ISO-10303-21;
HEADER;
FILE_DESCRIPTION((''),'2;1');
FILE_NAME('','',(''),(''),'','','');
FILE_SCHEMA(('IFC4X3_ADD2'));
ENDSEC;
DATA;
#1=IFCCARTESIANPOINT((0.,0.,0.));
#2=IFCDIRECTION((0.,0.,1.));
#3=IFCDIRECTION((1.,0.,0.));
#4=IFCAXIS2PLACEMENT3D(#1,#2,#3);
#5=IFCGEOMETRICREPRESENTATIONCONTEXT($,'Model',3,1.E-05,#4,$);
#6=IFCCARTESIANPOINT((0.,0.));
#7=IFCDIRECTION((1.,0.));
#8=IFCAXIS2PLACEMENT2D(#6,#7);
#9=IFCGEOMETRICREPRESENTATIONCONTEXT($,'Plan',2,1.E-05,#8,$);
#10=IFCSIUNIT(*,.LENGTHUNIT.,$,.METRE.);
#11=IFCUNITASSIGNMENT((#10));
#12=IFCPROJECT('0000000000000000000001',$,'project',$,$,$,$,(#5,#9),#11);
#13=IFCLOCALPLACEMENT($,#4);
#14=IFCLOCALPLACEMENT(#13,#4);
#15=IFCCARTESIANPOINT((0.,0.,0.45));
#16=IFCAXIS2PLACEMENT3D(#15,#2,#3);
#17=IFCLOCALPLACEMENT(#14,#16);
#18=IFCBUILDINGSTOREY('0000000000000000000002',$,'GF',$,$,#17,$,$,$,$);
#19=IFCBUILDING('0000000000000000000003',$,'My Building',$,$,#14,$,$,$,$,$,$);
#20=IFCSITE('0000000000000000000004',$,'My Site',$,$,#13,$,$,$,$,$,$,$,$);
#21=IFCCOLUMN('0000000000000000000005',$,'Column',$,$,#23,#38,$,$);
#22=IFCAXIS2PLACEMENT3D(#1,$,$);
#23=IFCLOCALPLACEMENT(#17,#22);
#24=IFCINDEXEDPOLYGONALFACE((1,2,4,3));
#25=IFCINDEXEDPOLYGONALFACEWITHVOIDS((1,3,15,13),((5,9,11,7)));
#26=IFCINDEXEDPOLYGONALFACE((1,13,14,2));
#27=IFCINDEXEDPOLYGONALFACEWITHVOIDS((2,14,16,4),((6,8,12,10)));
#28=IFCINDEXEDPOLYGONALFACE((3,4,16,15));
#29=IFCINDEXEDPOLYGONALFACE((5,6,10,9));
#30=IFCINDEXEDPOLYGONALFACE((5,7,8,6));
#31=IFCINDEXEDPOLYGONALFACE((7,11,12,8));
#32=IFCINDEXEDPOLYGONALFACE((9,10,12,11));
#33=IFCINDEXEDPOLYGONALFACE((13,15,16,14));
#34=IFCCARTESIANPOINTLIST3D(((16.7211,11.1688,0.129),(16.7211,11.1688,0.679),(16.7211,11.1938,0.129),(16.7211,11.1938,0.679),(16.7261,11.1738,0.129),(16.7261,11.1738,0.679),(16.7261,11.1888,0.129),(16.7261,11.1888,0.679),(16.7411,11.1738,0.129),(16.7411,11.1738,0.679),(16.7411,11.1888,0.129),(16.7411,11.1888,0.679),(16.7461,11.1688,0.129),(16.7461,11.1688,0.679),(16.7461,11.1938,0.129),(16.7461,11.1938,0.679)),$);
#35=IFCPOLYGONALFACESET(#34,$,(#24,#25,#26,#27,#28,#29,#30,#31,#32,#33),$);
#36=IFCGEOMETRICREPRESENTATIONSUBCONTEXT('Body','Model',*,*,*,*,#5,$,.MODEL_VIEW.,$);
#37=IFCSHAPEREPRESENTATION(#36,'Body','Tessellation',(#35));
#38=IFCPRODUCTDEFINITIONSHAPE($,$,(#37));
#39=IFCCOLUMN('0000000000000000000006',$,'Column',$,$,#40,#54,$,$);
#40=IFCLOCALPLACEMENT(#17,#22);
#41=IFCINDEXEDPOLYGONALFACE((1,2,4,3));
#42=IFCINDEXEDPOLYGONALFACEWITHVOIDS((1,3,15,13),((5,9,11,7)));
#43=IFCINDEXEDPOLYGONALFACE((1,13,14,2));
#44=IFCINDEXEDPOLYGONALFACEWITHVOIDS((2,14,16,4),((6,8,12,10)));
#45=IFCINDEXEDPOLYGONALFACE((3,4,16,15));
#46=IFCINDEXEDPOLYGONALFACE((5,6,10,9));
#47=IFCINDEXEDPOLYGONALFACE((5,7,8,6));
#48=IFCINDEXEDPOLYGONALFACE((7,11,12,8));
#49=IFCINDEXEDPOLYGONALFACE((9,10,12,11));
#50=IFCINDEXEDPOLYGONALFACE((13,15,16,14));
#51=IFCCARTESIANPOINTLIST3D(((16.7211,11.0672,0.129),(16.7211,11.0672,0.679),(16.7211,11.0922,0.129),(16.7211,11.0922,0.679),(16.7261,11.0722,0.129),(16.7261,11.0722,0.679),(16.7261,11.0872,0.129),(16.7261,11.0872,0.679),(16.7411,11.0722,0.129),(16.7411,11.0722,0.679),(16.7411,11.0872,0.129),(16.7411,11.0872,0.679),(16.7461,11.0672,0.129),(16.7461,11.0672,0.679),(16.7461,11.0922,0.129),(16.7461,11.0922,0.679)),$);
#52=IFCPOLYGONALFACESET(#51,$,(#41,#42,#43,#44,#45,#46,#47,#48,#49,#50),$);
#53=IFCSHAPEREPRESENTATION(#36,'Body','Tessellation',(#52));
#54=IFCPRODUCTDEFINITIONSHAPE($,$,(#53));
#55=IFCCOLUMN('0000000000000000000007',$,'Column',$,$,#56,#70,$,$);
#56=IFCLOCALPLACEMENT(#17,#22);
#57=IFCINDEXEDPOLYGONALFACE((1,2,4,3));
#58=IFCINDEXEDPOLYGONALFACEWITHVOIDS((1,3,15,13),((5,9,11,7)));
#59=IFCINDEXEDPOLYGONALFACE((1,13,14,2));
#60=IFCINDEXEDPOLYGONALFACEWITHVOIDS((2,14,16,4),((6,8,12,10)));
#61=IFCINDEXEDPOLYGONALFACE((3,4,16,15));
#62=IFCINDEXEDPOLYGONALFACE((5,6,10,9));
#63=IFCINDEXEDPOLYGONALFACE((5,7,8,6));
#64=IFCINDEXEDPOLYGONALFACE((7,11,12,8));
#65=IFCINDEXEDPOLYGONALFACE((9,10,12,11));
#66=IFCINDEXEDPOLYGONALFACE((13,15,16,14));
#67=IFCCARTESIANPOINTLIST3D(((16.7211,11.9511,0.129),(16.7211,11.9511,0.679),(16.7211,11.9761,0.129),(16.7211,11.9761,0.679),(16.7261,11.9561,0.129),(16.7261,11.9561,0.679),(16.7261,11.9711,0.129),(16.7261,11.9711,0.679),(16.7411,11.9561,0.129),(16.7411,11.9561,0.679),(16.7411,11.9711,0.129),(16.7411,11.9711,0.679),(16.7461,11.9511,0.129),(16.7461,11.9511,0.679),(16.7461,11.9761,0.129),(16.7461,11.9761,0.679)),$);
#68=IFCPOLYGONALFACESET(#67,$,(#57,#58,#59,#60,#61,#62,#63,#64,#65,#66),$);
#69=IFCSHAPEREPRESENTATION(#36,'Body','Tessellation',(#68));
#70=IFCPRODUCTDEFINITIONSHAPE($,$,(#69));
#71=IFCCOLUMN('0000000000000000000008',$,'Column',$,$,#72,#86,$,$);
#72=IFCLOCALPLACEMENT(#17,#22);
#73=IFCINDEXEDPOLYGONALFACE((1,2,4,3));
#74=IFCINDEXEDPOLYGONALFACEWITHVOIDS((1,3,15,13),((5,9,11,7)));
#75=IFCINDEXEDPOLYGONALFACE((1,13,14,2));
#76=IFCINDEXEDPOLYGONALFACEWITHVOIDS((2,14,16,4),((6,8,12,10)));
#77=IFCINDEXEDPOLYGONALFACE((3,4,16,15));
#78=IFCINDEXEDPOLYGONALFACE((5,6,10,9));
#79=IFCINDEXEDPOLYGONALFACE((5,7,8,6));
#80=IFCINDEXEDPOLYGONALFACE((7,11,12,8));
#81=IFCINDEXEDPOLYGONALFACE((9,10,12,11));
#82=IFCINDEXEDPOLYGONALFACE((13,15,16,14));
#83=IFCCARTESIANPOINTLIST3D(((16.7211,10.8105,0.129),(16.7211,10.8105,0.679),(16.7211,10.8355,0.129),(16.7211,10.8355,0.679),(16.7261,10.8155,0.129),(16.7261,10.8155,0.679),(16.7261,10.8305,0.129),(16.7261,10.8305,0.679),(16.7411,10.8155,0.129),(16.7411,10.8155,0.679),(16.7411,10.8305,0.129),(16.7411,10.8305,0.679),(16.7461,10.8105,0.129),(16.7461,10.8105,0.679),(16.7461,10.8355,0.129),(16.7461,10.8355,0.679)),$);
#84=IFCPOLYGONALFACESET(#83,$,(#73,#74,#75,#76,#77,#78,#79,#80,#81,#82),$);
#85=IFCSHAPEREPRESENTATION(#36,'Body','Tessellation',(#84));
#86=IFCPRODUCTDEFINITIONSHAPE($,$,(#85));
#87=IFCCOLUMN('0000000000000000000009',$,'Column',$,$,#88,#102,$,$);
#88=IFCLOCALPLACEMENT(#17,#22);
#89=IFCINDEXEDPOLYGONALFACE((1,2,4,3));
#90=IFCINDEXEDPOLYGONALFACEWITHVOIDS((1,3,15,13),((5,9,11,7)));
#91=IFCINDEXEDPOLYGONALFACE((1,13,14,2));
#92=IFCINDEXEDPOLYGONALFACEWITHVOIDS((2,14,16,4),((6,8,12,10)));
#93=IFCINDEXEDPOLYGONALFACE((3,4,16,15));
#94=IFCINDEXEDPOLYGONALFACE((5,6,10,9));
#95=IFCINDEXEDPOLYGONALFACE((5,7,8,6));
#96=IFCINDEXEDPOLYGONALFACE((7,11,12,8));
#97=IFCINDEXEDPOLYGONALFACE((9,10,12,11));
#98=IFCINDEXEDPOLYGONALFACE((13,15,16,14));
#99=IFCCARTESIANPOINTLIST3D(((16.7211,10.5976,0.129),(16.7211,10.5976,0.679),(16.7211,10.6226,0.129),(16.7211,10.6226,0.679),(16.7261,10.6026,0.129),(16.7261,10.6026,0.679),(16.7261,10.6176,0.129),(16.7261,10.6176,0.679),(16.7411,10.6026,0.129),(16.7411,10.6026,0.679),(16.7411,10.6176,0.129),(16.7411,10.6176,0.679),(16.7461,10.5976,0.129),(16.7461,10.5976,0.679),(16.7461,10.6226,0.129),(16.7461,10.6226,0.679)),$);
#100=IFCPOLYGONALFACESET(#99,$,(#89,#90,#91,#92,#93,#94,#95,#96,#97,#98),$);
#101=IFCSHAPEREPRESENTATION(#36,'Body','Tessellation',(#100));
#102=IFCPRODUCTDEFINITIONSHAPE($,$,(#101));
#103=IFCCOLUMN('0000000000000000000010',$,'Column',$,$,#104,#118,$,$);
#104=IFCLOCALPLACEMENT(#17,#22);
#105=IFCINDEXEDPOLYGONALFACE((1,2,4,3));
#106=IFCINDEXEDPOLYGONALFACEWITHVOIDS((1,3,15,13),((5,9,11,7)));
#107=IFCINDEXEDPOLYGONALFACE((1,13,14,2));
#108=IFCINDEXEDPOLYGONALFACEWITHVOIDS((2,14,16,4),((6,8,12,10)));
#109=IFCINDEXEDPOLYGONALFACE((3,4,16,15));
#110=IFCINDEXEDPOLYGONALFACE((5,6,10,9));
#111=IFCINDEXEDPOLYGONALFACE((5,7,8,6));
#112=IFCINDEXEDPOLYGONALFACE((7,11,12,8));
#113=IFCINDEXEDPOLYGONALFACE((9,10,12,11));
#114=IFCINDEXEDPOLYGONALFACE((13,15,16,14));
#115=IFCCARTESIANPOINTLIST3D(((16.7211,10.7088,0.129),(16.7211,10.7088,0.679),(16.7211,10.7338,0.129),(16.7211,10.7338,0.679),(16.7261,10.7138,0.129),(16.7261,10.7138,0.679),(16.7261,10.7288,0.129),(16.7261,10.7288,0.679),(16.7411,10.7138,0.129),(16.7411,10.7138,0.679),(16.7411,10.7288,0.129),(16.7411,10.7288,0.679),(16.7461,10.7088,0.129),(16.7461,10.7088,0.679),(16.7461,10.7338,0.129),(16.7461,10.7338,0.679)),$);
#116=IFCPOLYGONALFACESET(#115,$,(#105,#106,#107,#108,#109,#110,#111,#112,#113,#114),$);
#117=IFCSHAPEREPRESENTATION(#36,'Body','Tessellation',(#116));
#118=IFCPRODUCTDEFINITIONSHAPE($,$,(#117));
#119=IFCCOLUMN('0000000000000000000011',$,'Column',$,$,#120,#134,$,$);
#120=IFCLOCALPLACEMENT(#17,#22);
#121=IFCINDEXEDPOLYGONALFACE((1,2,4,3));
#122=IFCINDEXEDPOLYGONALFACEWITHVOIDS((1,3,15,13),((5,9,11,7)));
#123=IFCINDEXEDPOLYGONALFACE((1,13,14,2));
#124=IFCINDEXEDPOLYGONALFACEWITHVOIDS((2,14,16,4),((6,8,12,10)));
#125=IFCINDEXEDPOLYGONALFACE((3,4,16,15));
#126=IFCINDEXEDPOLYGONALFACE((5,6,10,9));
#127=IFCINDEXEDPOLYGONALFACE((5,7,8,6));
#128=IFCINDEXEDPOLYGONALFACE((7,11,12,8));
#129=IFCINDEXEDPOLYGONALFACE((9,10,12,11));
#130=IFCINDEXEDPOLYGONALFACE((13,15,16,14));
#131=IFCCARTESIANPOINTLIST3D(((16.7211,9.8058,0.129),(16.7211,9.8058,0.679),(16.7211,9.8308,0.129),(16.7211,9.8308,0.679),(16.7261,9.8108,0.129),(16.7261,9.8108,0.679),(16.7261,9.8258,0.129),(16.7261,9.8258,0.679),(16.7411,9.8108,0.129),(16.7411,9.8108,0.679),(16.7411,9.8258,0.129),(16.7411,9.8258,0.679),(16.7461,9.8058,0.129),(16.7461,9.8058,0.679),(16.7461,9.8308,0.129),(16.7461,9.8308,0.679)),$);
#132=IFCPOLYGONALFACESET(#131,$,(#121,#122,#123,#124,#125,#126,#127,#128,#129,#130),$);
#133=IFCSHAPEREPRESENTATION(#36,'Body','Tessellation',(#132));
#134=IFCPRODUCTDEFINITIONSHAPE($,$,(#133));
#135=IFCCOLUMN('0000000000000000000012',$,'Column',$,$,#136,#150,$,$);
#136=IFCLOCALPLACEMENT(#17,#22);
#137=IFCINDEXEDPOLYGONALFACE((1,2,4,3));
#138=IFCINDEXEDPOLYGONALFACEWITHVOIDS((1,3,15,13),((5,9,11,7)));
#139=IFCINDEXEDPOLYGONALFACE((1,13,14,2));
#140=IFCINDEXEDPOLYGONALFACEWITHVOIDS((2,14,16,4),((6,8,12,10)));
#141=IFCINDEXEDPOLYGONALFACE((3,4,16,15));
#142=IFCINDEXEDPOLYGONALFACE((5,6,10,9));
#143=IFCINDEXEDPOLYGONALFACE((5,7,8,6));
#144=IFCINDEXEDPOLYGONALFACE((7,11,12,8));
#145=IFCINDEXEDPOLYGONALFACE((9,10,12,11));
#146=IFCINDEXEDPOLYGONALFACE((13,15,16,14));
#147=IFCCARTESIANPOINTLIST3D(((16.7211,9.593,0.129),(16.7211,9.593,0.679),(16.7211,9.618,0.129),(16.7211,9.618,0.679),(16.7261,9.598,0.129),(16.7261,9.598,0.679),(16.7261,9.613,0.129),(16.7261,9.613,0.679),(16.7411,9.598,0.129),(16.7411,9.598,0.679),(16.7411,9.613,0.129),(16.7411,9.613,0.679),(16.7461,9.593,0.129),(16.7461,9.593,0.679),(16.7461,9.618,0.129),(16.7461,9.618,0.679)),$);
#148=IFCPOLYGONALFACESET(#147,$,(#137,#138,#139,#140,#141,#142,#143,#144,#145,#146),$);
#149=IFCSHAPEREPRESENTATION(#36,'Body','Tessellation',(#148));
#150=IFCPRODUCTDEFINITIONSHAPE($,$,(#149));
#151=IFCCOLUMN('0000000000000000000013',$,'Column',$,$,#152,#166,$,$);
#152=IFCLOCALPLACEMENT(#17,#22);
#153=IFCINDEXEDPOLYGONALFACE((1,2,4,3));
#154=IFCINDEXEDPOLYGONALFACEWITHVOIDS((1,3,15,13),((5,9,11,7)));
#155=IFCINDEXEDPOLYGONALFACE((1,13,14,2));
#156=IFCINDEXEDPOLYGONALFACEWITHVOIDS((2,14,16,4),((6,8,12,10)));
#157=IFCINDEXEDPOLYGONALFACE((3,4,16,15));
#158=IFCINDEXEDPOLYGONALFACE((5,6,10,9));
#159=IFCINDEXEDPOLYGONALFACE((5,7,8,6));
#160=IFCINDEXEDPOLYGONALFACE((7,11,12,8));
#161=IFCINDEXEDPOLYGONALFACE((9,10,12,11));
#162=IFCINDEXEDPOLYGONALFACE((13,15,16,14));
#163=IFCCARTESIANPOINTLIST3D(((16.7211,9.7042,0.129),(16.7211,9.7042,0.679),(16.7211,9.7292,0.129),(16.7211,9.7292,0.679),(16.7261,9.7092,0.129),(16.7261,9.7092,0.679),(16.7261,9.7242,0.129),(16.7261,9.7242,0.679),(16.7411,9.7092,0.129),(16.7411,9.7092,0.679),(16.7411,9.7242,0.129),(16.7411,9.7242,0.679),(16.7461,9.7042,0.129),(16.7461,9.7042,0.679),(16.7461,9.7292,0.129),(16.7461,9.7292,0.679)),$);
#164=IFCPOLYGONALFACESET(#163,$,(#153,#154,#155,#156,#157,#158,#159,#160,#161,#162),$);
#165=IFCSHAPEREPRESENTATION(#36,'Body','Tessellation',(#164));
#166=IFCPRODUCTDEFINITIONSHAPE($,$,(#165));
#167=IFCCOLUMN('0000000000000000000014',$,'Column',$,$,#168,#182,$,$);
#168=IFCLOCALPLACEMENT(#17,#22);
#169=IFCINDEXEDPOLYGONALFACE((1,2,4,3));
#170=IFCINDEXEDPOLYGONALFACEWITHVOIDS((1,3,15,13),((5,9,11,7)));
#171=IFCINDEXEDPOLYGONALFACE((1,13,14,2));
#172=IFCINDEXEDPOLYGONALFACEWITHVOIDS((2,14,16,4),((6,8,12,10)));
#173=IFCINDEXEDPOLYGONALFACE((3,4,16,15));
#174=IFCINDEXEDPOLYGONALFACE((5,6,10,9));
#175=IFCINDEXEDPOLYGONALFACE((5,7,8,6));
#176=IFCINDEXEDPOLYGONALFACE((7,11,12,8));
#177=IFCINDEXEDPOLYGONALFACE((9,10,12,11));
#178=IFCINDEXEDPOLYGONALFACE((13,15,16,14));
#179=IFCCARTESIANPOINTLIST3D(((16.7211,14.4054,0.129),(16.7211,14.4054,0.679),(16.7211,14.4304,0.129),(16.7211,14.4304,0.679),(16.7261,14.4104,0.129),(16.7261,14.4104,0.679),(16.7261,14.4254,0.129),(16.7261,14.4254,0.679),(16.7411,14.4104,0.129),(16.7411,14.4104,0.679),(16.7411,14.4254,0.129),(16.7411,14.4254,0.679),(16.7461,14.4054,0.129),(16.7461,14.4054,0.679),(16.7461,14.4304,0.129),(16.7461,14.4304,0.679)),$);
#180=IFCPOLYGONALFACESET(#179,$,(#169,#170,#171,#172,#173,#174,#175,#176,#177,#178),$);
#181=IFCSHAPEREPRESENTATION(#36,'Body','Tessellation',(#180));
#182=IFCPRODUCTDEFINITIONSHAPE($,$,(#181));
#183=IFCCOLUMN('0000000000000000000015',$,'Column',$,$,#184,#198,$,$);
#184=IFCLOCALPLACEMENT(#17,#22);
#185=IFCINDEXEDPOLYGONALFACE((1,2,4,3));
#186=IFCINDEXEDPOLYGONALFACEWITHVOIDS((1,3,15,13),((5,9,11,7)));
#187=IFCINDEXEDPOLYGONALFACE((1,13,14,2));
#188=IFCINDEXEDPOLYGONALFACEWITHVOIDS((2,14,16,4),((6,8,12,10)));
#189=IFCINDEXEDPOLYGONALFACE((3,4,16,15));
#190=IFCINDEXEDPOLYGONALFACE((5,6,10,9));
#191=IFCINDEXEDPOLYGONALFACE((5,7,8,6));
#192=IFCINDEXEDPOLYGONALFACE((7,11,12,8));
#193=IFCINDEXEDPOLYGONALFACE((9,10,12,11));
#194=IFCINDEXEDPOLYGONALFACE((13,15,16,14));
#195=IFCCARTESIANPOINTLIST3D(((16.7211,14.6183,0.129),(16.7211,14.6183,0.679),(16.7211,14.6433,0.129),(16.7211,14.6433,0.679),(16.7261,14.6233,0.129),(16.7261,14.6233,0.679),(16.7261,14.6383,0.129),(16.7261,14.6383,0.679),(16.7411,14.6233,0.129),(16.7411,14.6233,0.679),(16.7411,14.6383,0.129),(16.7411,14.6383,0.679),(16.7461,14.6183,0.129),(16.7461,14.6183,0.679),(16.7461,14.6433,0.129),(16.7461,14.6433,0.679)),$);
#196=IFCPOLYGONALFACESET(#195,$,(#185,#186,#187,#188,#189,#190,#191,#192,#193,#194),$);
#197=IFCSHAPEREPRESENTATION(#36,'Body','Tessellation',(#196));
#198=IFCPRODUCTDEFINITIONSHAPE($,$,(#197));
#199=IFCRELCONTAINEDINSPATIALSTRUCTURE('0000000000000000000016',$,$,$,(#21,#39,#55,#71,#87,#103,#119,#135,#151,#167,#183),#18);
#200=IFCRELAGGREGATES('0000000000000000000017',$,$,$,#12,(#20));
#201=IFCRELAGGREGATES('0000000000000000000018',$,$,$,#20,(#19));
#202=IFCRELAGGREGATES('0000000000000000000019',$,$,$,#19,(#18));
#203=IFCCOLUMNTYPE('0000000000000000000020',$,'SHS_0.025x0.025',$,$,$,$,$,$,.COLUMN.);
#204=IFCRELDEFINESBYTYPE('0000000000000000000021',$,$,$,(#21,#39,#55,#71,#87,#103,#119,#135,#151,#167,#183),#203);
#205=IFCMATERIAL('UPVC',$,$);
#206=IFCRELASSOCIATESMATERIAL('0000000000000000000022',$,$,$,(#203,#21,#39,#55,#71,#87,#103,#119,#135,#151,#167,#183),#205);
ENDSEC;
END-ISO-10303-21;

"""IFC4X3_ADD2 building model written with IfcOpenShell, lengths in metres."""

from ifc_helpers import new_model, si_unit, frame, origin_with_axes, origin_2d_with_axis, place, context, subcontext, project, spatial, hollow_rectangle, extrude, material, material_profile, profile_set, profile_usage, type_object, element, save


model = new_model("IFC4X3_ADD2")

# Units and contexts
model_context = context("Model", 3, precision=1e-05, world=origin_with_axes())
plan_context = context("Plan", 2, precision=1e-05, world=origin_2d_with_axis())
body_context = subcontext(model_context, "Body", "Model", "MODEL_VIEW")
ifc_project = project(units=[si_unit("LENGTHUNIT", "METRE")], contexts=[model_context, plan_context])

# Site, building, storey
site_placement = place(None, origin_with_axes())
site = spatial("IfcSite", under=ifc_project, at=site_placement, Name="My Site")
building_placement = place(site_placement, origin_with_axes())
building = spatial("IfcBuilding", under=site, at=building_placement, Name="My Building")
storey_placement = place(building_placement, frame((0.0, 0.0, 0.45), z_axis=(0.0, 0.0, 1.0), x_axis=(1.0, 0.0, 0.0)))
storey = spatial("IfcBuildingStorey", under=building, at=storey_placement, Name="GF")

# Columns
ifc_material_1 = material(Name="UPVC")
ifc_material_profile_1 = material_profile(ifc_material_1, hollow_rectangle(XDim=0.025, YDim=0.025, WallThickness=0.005))
ifc_profile_set_1 = profile_set([ifc_material_profile_1])
ifc_profile_usage_1 = profile_usage(ifc_profile_set_1)
column_type_1 = type_object("IfcColumnType", Name="SHS_0.025x0.025", PredefinedType="COLUMN", material=ifc_profile_set_1)
column_1_placement = place(storey_placement, frame((16.7336, 11.1813, 0.129), z_axis=(0.0, 0.0, 1.0), x_axis=(0.0, -1.0, 0.0)))
element("IfcColumn", 1, at=column_1_placement, inside=storey, type_object=column_type_1, material=ifc_profile_usage_1, Name="Column", context=body_context, shape_type="SweptSolid", body=[
    extrude(hollow_rectangle(XDim=0.025, YDim=0.025, WallThickness=0.005), origin_with_axes(), (0.0, 0.0, 1.0), 0.55),
])
ifc_profile_usage_2 = profile_usage(ifc_profile_set_1)
column_2_placement = place(storey_placement, frame((16.7336, 11.0797, 0.129), z_axis=(0.0, 0.0, 1.0), x_axis=(0.0, -1.0, 0.0)))
element("IfcColumn", 2, at=column_2_placement, inside=storey, type_object=column_type_1, material=ifc_profile_usage_2, Name="Column", context=body_context, shape_type="SweptSolid", body=[
    extrude(hollow_rectangle(XDim=0.025, YDim=0.025, WallThickness=0.005), origin_with_axes(), (0.0, 0.0, 1.0), 0.55),
])
ifc_profile_usage_3 = profile_usage(ifc_profile_set_1)
column_3_placement = place(storey_placement, frame((16.7336, 11.9636, 0.129), z_axis=(0.0, 0.0, 1.0), x_axis=(0.0, -1.0, 0.0)))
element("IfcColumn", 3, at=column_3_placement, inside=storey, type_object=column_type_1, material=ifc_profile_usage_3, Name="Column", context=body_context, shape_type="SweptSolid", body=[
    extrude(hollow_rectangle(XDim=0.025, YDim=0.025, WallThickness=0.005), origin_with_axes(), (0.0, 0.0, 1.0), 0.55),
])
ifc_profile_usage_4 = profile_usage(ifc_profile_set_1)
column_4_placement = place(storey_placement, frame((16.7336, 10.823, 0.129), z_axis=(0.0, 0.0, 1.0), x_axis=(0.0, -1.0, 0.0)))
element("IfcColumn", 4, at=column_4_placement, inside=storey, type_object=column_type_1, material=ifc_profile_usage_4, Name="Column", context=body_context, shape_type="SweptSolid", body=[
    extrude(hollow_rectangle(XDim=0.025, YDim=0.025, WallThickness=0.005), origin_with_axes(), (0.0, 0.0, 1.0), 0.55),
])
ifc_profile_usage_5 = profile_usage(ifc_profile_set_1)
column_5_placement = place(storey_placement, frame((16.7336, 10.6101, 0.129), z_axis=(0.0, 0.0, 1.0), x_axis=(0.0, -1.0, 0.0)))
element("IfcColumn", 5, at=column_5_placement, inside=storey, type_object=column_type_1, material=ifc_profile_usage_5, Name="Column", context=body_context, shape_type="SweptSolid", body=[
    extrude(hollow_rectangle(XDim=0.025, YDim=0.025, WallThickness=0.005), origin_with_axes(), (0.0, 0.0, 1.0), 0.55),
])
ifc_profile_usage_6 = profile_usage(ifc_profile_set_1)
column_6_placement = place(storey_placement, frame((16.7336, 10.7213, 0.129), z_axis=(0.0, 0.0, 1.0), x_axis=(0.0, -1.0, 0.0)))
element("IfcColumn", 6, at=column_6_placement, inside=storey, type_object=column_type_1, material=ifc_profile_usage_6, Name="Column", context=body_context, shape_type="SweptSolid", body=[
    extrude(hollow_rectangle(XDim=0.025, YDim=0.025, WallThickness=0.005), origin_with_axes(), (0.0, 0.0, 1.0), 0.55),
])
ifc_profile_usage_7 = profile_usage(ifc_profile_set_1)
column_7_placement = place(storey_placement, frame((16.7336, 9.8183, 0.129), z_axis=(0.0, 0.0, 1.0), x_axis=(0.0, -1.0, 0.0)))
element("IfcColumn", 7, at=column_7_placement, inside=storey, type_object=column_type_1, material=ifc_profile_usage_7, Name="Column", context=body_context, shape_type="SweptSolid", body=[
    extrude(hollow_rectangle(XDim=0.025, YDim=0.025, WallThickness=0.005), origin_with_axes(), (0.0, 0.0, 1.0), 0.55),
])
ifc_profile_usage_8 = profile_usage(ifc_profile_set_1)
column_8_placement = place(storey_placement, frame((16.7336, 9.6055, 0.129), z_axis=(0.0, 0.0, 1.0), x_axis=(0.0, -1.0, 0.0)))
element("IfcColumn", 8, at=column_8_placement, inside=storey, type_object=column_type_1, material=ifc_profile_usage_8, Name="Column", context=body_context, shape_type="SweptSolid", body=[
    extrude(hollow_rectangle(XDim=0.025, YDim=0.025, WallThickness=0.005), origin_with_axes(), (0.0, 0.0, 1.0), 0.55),
])
ifc_profile_usage_9 = profile_usage(ifc_profile_set_1)
column_9_placement = place(storey_placement, frame((16.7336, 9.7167, 0.129), z_axis=(0.0, 0.0, 1.0), x_axis=(0.0, -1.0, 0.0)))
element("IfcColumn", 9, at=column_9_placement, inside=storey, type_object=column_type_1, material=ifc_profile_usage_9, Name="Column", context=body_context, shape_type="SweptSolid", body=[
    extrude(hollow_rectangle(XDim=0.025, YDim=0.025, WallThickness=0.005), origin_with_axes(), (0.0, 0.0, 1.0), 0.55),
])
ifc_profile_usage_10 = profile_usage(ifc_profile_set_1)
column_10_placement = place(storey_placement, frame((16.7336, 14.4179, 0.129), z_axis=(0.0, 0.0, 1.0), x_axis=(0.0, -1.0, 0.0)))
element("IfcColumn", 10, at=column_10_placement, inside=storey, type_object=column_type_1, material=ifc_profile_usage_10, Name="Column", context=body_context, shape_type="SweptSolid", body=[
    extrude(hollow_rectangle(XDim=0.025, YDim=0.025, WallThickness=0.005), origin_with_axes(), (0.0, 0.0, 1.0), 0.55),
])
ifc_profile_usage_11 = profile_usage(ifc_profile_set_1)
column_11_placement = place(storey_placement, frame((16.7336, 14.6308, 0.129), z_axis=(0.0, 0.0, 1.0), x_axis=(0.0, -1.0, 0.0)))
element("IfcColumn", 11, at=column_11_placement, inside=storey, type_object=column_type_1, material=ifc_profile_usage_11, Name="Column", context=body_context, shape_type="SweptSolid", body=[
    extrude(hollow_rectangle(XDim=0.025, YDim=0.025, WallThickness=0.005), origin_with_axes(), (0.0, 0.0, 1.0), 0.55),
])

save(model, "model.ifc")
